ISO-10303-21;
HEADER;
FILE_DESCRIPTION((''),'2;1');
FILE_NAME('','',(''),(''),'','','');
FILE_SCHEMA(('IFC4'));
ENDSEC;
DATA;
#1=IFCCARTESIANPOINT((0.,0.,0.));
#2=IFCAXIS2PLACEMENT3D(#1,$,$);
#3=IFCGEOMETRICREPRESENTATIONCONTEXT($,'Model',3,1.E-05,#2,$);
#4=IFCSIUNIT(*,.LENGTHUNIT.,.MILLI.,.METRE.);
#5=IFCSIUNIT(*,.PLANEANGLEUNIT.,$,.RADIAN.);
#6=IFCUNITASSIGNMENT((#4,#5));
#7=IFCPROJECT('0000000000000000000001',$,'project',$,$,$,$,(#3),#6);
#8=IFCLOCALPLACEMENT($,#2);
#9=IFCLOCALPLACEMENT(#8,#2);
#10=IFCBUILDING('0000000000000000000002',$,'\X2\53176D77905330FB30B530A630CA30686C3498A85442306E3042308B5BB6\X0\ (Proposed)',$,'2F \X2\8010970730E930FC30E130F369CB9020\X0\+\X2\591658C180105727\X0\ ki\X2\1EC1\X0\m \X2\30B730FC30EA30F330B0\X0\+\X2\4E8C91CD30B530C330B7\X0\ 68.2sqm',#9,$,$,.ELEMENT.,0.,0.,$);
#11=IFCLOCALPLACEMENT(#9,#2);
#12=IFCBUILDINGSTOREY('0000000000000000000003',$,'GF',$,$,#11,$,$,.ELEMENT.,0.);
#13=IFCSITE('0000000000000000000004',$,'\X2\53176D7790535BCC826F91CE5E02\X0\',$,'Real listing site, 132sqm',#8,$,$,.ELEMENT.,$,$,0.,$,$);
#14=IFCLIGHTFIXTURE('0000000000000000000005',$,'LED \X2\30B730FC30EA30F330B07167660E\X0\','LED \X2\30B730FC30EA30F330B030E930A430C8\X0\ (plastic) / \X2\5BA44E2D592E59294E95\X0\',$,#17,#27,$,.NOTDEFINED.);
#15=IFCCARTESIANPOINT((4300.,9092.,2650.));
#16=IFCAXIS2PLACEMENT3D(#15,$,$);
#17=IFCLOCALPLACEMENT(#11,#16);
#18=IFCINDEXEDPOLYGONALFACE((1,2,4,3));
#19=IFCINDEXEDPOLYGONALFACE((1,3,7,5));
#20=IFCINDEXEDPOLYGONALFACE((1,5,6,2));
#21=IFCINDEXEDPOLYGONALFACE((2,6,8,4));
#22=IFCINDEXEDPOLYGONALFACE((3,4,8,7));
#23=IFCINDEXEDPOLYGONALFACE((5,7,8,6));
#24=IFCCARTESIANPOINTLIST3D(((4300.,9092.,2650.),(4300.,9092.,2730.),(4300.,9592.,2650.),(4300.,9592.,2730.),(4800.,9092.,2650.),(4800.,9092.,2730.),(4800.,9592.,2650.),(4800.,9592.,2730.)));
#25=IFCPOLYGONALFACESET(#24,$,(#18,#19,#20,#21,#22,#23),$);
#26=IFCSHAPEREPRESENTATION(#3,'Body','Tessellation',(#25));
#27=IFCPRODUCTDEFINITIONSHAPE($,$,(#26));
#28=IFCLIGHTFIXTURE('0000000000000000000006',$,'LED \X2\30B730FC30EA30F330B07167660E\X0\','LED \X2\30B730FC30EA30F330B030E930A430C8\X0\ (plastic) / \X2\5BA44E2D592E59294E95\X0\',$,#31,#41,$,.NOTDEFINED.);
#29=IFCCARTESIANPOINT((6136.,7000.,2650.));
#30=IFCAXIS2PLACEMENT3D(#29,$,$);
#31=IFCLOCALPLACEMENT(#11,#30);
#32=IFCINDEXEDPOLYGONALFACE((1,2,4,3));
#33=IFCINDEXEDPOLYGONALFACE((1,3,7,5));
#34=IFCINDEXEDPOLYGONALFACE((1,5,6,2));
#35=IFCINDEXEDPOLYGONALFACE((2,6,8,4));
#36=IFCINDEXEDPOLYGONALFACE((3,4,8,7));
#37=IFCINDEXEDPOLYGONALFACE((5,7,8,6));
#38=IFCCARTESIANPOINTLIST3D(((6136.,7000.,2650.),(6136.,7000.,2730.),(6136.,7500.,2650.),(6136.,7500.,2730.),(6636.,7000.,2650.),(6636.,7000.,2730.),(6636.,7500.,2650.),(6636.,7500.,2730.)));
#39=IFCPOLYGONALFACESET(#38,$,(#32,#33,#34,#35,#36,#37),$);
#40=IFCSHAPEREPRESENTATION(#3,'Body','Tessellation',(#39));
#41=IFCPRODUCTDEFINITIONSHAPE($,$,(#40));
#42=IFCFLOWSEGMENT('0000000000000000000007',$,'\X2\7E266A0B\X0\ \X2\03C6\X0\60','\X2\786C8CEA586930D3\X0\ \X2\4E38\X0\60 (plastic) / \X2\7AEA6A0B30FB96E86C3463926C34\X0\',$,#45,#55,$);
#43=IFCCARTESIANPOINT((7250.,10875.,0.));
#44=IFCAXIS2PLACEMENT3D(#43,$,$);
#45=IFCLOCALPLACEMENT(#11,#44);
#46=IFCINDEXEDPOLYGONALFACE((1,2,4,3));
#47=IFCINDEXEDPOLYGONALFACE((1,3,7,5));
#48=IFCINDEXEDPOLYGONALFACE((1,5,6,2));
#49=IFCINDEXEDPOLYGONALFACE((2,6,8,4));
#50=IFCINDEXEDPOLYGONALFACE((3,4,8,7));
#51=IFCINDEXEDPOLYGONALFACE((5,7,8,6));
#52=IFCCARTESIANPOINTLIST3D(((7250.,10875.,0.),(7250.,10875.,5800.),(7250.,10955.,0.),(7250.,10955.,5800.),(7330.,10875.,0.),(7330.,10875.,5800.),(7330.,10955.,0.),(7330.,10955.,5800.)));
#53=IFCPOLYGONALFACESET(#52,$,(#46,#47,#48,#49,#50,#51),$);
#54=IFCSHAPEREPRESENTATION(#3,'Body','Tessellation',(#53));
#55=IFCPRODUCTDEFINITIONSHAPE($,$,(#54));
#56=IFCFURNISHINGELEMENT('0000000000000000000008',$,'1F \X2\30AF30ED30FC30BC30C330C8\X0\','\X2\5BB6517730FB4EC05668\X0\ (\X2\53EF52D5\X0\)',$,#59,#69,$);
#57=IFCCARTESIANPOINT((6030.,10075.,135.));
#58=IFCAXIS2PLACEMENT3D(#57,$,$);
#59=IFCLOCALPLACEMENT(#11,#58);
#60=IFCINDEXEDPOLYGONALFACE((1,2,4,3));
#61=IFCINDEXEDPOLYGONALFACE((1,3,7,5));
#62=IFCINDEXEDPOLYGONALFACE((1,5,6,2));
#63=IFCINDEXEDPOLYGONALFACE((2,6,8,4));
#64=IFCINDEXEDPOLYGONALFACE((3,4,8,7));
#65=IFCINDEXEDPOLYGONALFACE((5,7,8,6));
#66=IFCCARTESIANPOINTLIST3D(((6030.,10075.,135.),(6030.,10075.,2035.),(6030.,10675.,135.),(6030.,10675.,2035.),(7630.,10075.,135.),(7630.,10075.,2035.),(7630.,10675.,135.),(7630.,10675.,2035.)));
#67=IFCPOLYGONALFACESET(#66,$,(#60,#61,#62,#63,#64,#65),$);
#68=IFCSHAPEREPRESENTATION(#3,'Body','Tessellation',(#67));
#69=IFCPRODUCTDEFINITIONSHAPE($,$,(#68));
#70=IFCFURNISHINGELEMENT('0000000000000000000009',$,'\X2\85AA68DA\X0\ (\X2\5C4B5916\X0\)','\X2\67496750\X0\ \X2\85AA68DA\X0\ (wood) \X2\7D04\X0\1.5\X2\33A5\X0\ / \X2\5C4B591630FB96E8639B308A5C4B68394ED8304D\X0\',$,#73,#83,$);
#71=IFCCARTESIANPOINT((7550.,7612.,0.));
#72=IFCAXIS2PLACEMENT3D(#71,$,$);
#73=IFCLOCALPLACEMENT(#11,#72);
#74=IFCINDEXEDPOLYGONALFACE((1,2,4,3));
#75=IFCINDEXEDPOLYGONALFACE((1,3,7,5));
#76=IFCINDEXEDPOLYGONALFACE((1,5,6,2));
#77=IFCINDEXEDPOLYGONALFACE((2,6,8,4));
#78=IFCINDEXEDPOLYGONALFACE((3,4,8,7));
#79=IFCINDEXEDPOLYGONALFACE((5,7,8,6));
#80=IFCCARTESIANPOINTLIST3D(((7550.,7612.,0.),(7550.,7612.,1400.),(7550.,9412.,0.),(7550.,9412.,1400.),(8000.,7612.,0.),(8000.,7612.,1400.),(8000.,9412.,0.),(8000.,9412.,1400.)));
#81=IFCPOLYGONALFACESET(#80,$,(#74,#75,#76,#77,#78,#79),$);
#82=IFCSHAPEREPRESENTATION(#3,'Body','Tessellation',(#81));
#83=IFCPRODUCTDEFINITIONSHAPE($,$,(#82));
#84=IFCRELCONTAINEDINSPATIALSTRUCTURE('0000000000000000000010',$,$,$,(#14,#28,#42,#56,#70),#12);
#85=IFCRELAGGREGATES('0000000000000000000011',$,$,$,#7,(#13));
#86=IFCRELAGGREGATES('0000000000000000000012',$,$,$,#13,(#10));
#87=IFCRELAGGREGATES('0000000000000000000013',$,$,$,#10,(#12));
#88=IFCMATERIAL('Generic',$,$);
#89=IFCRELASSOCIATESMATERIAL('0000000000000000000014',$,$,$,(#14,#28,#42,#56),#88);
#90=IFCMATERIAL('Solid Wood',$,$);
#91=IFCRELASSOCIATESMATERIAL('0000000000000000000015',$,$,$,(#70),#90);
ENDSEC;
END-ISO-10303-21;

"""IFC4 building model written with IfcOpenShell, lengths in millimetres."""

from ifc_helpers import new_model, si_unit, frame, frame_2d, origin, place, context, project, spatial, rectangle, extrude, material, element, save


model = new_model("IFC4")

# Units and contexts
model_context = context("Model", 3, precision=1e-05, world=origin())
ifc_project = project(units=[si_unit("LENGTHUNIT", "METRE", prefix="MILLI"), si_unit("PLANEANGLEUNIT", "RADIAN")], contexts=[model_context])

# Site, building, storey
site_placement = place(None, origin())
site = spatial("IfcSite", under=ifc_project, at=site_placement, Name="北海道富良野市", ObjectType="Real listing site, 132sqm", CompositionType="ELEMENT", RefElevation=0.0)
building_placement = place(site_placement, origin())
building = spatial("IfcBuilding", under=site, at=building_placement, Name="北海道・サウナと水風呂のある家 (Proposed)", ObjectType="2F 耐震ラーメン構造+外壁耐圧 kiềm シーリング+二重サッシ 68.2sqm", CompositionType="ELEMENT", ElevationOfRefHeight=0.0, ElevationOfTerrain=0.0)
storey_placement = place(building_placement, origin())
storey = spatial("IfcBuildingStorey", under=building, at=storey_placement, Name="GF", CompositionType="ELEMENT", Elevation=0.0)

# Shared definitions
ifc_material_1 = material(Name="Solid Wood")

# Shared definitions
ifc_material_2 = material(Name="Generic")

# Light fixtures
light_fixture_1_placement = place(storey_placement, frame((4300.0, 9092.0, 2650.0)))
element("IfcLightFixture", 1, at=light_fixture_1_placement, inside=storey, material=ifc_material_2, Name="LED シーリング照明", Description="LED シーリングライト (plastic) / 室中央天井", PredefinedType="NOTDEFINED", context=model_context, shape_type="SweptSolid", body=[
    extrude(rectangle(XDim=500.0, YDim=500.0, at=frame_2d((250.0, 250.0))), frame((4300.0, 9092.0, 2650.0)), (0.0, 0.0, 1.0), 80.0),
])
light_fixture_2_placement = place(storey_placement, frame((6136.0, 7000.0, 2650.0)))
element("IfcLightFixture", 2, at=light_fixture_2_placement, inside=storey, material=ifc_material_2, Name="LED シーリング照明", Description="LED シーリングライト (plastic) / 室中央天井", PredefinedType="NOTDEFINED", context=model_context, shape_type="SweptSolid", body=[
    extrude(rectangle(XDim=500.0, YDim=500.0, at=frame_2d((250.0, 250.0))), frame((6136.0, 7000.0, 2650.0)), (0.0, 0.0, 1.0), 80.0),
])

# Flow segment
flow_segment_placement = place(storey_placement, frame((7250.0, 10875.0, 0.0)))
element("IfcFlowSegment", 3, at=flow_segment_placement, inside=storey, material=ifc_material_2, Name="縦樋 φ60", Description="硬質塩ビ 丸60 (plastic) / 竪樋・雨水排水", context=model_context, shape_type="SweptSolid", body=[
    extrude(rectangle(XDim=80.0, YDim=80.0, at=frame_2d((40.0, 40.0))), frame((7250.0, 10875.0, 0.0)), (0.0, 0.0, 1.0), 5800.0),
])

# Furnishing elements
furnishing_1_placement = place(storey_placement, frame((6030.0, 10075.0, 135.0)))
element("IfcFurnishingElement", 4, at=furnishing_1_placement, inside=storey, material=ifc_material_2, Name="1F クローゼット", Description="家具・什器 (可動)", context=model_context, shape_type="SweptSolid", body=[
    extrude(rectangle(XDim=1600.0, YDim=600.0, at=frame_2d((800.0, 300.0))), frame((6030.0, 10075.0, 135.0)), (0.0, 0.0, 1.0), 1900.0),
])
furnishing_2_placement = place(storey_placement, frame((7550.0, 7612.0, 0.0)))
element("IfcFurnishingElement", 5, at=furnishing_2_placement, inside=storey, material=ifc_material_1, Name="薪棚 (屋外)", Description="杉材 薪棚 (wood) 約1.5㎥ / 屋外・雨掛り屋根付き", context=model_context, shape_type="SweptSolid", body=[
    extrude(rectangle(XDim=450.0, YDim=1800.0, at=frame_2d((225.0, 900.0))), frame((7550.0, 7612.0, 0.0)), (0.0, 0.0, 1.0), 1400.0),
])

save(model, "model.ifc")
